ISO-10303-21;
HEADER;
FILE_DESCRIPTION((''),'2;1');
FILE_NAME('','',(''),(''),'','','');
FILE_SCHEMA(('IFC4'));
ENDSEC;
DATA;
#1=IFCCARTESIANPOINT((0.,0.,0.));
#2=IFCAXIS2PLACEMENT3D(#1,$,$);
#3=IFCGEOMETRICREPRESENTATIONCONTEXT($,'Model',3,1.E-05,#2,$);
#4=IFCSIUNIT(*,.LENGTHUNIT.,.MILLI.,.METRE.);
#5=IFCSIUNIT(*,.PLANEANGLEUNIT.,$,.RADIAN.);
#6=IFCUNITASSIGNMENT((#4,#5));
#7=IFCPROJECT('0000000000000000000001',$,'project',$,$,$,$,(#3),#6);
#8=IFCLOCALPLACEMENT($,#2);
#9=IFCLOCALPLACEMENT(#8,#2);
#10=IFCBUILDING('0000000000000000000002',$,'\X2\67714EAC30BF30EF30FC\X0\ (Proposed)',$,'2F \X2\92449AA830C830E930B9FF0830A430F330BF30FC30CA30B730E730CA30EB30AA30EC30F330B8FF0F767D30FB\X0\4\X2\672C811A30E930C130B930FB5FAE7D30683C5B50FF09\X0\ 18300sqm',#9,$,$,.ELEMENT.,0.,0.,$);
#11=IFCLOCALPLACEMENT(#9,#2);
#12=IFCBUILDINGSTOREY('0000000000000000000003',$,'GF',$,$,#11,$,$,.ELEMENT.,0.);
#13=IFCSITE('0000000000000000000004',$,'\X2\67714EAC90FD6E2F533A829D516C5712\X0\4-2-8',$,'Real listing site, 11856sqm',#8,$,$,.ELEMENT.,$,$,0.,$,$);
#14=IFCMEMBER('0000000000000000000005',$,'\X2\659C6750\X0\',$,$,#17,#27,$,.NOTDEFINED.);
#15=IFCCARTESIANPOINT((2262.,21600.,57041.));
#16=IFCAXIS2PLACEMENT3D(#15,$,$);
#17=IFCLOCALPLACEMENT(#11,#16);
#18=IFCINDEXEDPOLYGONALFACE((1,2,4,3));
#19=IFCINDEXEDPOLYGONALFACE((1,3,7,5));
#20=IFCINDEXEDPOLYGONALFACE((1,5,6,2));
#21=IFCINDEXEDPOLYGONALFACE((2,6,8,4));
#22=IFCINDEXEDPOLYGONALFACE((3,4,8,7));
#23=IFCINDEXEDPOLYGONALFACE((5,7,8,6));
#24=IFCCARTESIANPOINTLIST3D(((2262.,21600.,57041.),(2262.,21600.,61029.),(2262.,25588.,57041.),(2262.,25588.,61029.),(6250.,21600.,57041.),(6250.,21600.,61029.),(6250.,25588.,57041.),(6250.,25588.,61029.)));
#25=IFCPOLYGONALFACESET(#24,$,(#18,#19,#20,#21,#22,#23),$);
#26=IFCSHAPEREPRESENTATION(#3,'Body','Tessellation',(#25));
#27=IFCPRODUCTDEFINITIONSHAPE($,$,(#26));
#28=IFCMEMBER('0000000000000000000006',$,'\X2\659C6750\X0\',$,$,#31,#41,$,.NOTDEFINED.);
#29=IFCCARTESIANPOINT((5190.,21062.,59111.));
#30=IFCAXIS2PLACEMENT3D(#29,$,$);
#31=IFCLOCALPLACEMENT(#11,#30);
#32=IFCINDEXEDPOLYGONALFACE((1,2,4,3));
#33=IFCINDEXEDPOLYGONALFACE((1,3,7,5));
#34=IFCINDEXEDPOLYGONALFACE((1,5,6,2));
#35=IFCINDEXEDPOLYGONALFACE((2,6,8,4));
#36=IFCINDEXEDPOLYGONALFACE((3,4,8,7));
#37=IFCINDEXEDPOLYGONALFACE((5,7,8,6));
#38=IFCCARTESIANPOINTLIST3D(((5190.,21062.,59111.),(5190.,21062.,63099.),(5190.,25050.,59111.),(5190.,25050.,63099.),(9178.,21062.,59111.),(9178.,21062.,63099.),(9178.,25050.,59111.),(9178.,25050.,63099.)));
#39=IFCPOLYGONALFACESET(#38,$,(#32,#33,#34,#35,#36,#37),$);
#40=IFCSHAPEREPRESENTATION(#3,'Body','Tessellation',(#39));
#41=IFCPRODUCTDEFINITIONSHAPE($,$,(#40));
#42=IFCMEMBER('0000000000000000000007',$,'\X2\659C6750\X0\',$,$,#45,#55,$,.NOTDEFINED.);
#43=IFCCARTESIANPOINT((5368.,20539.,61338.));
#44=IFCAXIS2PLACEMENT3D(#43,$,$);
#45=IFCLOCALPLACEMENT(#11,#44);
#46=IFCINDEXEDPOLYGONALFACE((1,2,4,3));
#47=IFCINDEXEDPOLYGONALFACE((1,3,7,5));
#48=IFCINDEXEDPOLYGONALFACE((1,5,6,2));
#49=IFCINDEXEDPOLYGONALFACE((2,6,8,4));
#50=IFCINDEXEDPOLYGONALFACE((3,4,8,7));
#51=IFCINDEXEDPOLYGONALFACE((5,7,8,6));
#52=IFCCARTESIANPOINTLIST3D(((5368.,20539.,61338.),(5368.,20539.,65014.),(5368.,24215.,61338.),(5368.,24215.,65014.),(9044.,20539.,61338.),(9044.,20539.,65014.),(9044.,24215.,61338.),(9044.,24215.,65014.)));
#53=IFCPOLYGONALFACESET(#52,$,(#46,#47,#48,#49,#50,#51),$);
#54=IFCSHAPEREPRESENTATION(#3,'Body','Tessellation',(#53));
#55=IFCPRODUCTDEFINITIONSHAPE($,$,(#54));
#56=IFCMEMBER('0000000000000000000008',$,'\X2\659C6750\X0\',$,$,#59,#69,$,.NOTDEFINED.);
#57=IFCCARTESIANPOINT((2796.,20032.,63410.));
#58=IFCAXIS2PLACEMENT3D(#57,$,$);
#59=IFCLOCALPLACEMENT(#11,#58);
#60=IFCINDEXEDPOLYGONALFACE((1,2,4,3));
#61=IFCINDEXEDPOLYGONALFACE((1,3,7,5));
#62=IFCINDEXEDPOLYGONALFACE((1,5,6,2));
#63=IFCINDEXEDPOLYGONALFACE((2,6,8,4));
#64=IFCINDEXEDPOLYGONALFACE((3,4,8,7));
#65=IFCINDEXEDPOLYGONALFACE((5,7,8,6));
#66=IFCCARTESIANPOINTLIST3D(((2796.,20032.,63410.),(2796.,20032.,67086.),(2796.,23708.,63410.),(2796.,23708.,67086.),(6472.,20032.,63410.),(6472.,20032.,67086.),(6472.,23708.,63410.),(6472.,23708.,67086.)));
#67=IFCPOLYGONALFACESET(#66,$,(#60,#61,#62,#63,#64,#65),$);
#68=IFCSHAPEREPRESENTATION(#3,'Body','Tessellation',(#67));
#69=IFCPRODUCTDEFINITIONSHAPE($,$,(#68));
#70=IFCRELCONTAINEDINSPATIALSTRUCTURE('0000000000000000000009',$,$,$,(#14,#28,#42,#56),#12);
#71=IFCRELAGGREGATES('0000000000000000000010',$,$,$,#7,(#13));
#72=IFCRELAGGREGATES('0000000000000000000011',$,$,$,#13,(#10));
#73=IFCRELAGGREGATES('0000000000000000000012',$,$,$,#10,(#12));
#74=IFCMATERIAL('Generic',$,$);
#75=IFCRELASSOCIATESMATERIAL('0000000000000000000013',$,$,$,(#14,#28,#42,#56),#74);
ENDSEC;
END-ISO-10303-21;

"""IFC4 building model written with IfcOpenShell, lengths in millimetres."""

from ifc_helpers import new_model, si_unit, frame, frame_2d, origin, place, context, project, spatial, rectangle, extrude, material, element, save


model = new_model("IFC4")

# Units and contexts
model_context = context("Model", 3, precision=1e-05, world=origin())
ifc_project = project(units=[si_unit("LENGTHUNIT", "METRE", prefix="MILLI"), si_unit("PLANEANGLEUNIT", "RADIAN")], contexts=[model_context])

# Site, building, storey
site_placement = place(None, origin())
site = spatial("IfcSite", under=ifc_project, at=site_placement, Name="東京都港区芝公園4-2-8", ObjectType="Real listing site, 11856sqm", CompositionType="ELEMENT", RefElevation=0.0)
building_placement = place(site_placement, origin())
building = spatial("IfcBuilding", under=site, at=building_placement, Name="東京タワー (Proposed)", ObjectType="2F 鉄骨トラス（インターナショナルオレンジ／白・4本脚ラチス・微細格子） 18300sqm", CompositionType="ELEMENT", ElevationOfRefHeight=0.0, ElevationOfTerrain=0.0)
storey_placement = place(building_placement, origin())
storey = spatial("IfcBuildingStorey", under=building, at=storey_placement, Name="GF", CompositionType="ELEMENT", Elevation=0.0)

# Shared definitions
ifc_material = material(Name="Generic")

# Members
member_1_placement = place(storey_placement, frame((2262.0, 21600.0, 57041.0)))
element("IfcMember", 1, at=member_1_placement, inside=storey, material=ifc_material, Name="斜材", PredefinedType="NOTDEFINED", context=model_context, shape_type="SweptSolid", body=[
    extrude(rectangle(XDim=3988.0, YDim=3988.0, at=frame_2d((1994.0, 1994.0))), frame((2262.0, 21600.0, 57041.0)), (0.0, 0.0, 1.0), 3988.0),
])
member_2_placement = place(storey_placement, frame((5190.0, 21062.0, 59111.0)))
element("IfcMember", 2, at=member_2_placement, inside=storey, material=ifc_material, Name="斜材", PredefinedType="NOTDEFINED", context=model_context, shape_type="SweptSolid", body=[
    extrude(rectangle(XDim=3988.0, YDim=3988.0, at=frame_2d((1994.0, 1994.0))), frame((5190.0, 21062.0, 59111.0)), (0.0, 0.0, 1.0), 3988.0),
])
member_3_placement = place(storey_placement, frame((5368.0, 20539.0, 61338.0)))
element("IfcMember", 3, at=member_3_placement, inside=storey, material=ifc_material, Name="斜材", PredefinedType="NOTDEFINED", context=model_context, shape_type="SweptSolid", body=[
    extrude(rectangle(XDim=3676.0, YDim=3676.0, at=frame_2d((1838.0, 1838.0))), frame((5368.0, 20539.0, 61338.0)), (0.0, 0.0, 1.0), 3676.0),
])
member_4_placement = place(storey_placement, frame((2796.0, 20032.0, 63410.0)))
element("IfcMember", 4, at=member_4_placement, inside=storey, material=ifc_material, Name="斜材", PredefinedType="NOTDEFINED", context=model_context, shape_type="SweptSolid", body=[
    extrude(rectangle(XDim=3676.0, YDim=3676.0, at=frame_2d((1838.0, 1838.0))), frame((2796.0, 20032.0, 63410.0)), (0.0, 0.0, 1.0), 3676.0),
])

save(model, "model.ifc")
